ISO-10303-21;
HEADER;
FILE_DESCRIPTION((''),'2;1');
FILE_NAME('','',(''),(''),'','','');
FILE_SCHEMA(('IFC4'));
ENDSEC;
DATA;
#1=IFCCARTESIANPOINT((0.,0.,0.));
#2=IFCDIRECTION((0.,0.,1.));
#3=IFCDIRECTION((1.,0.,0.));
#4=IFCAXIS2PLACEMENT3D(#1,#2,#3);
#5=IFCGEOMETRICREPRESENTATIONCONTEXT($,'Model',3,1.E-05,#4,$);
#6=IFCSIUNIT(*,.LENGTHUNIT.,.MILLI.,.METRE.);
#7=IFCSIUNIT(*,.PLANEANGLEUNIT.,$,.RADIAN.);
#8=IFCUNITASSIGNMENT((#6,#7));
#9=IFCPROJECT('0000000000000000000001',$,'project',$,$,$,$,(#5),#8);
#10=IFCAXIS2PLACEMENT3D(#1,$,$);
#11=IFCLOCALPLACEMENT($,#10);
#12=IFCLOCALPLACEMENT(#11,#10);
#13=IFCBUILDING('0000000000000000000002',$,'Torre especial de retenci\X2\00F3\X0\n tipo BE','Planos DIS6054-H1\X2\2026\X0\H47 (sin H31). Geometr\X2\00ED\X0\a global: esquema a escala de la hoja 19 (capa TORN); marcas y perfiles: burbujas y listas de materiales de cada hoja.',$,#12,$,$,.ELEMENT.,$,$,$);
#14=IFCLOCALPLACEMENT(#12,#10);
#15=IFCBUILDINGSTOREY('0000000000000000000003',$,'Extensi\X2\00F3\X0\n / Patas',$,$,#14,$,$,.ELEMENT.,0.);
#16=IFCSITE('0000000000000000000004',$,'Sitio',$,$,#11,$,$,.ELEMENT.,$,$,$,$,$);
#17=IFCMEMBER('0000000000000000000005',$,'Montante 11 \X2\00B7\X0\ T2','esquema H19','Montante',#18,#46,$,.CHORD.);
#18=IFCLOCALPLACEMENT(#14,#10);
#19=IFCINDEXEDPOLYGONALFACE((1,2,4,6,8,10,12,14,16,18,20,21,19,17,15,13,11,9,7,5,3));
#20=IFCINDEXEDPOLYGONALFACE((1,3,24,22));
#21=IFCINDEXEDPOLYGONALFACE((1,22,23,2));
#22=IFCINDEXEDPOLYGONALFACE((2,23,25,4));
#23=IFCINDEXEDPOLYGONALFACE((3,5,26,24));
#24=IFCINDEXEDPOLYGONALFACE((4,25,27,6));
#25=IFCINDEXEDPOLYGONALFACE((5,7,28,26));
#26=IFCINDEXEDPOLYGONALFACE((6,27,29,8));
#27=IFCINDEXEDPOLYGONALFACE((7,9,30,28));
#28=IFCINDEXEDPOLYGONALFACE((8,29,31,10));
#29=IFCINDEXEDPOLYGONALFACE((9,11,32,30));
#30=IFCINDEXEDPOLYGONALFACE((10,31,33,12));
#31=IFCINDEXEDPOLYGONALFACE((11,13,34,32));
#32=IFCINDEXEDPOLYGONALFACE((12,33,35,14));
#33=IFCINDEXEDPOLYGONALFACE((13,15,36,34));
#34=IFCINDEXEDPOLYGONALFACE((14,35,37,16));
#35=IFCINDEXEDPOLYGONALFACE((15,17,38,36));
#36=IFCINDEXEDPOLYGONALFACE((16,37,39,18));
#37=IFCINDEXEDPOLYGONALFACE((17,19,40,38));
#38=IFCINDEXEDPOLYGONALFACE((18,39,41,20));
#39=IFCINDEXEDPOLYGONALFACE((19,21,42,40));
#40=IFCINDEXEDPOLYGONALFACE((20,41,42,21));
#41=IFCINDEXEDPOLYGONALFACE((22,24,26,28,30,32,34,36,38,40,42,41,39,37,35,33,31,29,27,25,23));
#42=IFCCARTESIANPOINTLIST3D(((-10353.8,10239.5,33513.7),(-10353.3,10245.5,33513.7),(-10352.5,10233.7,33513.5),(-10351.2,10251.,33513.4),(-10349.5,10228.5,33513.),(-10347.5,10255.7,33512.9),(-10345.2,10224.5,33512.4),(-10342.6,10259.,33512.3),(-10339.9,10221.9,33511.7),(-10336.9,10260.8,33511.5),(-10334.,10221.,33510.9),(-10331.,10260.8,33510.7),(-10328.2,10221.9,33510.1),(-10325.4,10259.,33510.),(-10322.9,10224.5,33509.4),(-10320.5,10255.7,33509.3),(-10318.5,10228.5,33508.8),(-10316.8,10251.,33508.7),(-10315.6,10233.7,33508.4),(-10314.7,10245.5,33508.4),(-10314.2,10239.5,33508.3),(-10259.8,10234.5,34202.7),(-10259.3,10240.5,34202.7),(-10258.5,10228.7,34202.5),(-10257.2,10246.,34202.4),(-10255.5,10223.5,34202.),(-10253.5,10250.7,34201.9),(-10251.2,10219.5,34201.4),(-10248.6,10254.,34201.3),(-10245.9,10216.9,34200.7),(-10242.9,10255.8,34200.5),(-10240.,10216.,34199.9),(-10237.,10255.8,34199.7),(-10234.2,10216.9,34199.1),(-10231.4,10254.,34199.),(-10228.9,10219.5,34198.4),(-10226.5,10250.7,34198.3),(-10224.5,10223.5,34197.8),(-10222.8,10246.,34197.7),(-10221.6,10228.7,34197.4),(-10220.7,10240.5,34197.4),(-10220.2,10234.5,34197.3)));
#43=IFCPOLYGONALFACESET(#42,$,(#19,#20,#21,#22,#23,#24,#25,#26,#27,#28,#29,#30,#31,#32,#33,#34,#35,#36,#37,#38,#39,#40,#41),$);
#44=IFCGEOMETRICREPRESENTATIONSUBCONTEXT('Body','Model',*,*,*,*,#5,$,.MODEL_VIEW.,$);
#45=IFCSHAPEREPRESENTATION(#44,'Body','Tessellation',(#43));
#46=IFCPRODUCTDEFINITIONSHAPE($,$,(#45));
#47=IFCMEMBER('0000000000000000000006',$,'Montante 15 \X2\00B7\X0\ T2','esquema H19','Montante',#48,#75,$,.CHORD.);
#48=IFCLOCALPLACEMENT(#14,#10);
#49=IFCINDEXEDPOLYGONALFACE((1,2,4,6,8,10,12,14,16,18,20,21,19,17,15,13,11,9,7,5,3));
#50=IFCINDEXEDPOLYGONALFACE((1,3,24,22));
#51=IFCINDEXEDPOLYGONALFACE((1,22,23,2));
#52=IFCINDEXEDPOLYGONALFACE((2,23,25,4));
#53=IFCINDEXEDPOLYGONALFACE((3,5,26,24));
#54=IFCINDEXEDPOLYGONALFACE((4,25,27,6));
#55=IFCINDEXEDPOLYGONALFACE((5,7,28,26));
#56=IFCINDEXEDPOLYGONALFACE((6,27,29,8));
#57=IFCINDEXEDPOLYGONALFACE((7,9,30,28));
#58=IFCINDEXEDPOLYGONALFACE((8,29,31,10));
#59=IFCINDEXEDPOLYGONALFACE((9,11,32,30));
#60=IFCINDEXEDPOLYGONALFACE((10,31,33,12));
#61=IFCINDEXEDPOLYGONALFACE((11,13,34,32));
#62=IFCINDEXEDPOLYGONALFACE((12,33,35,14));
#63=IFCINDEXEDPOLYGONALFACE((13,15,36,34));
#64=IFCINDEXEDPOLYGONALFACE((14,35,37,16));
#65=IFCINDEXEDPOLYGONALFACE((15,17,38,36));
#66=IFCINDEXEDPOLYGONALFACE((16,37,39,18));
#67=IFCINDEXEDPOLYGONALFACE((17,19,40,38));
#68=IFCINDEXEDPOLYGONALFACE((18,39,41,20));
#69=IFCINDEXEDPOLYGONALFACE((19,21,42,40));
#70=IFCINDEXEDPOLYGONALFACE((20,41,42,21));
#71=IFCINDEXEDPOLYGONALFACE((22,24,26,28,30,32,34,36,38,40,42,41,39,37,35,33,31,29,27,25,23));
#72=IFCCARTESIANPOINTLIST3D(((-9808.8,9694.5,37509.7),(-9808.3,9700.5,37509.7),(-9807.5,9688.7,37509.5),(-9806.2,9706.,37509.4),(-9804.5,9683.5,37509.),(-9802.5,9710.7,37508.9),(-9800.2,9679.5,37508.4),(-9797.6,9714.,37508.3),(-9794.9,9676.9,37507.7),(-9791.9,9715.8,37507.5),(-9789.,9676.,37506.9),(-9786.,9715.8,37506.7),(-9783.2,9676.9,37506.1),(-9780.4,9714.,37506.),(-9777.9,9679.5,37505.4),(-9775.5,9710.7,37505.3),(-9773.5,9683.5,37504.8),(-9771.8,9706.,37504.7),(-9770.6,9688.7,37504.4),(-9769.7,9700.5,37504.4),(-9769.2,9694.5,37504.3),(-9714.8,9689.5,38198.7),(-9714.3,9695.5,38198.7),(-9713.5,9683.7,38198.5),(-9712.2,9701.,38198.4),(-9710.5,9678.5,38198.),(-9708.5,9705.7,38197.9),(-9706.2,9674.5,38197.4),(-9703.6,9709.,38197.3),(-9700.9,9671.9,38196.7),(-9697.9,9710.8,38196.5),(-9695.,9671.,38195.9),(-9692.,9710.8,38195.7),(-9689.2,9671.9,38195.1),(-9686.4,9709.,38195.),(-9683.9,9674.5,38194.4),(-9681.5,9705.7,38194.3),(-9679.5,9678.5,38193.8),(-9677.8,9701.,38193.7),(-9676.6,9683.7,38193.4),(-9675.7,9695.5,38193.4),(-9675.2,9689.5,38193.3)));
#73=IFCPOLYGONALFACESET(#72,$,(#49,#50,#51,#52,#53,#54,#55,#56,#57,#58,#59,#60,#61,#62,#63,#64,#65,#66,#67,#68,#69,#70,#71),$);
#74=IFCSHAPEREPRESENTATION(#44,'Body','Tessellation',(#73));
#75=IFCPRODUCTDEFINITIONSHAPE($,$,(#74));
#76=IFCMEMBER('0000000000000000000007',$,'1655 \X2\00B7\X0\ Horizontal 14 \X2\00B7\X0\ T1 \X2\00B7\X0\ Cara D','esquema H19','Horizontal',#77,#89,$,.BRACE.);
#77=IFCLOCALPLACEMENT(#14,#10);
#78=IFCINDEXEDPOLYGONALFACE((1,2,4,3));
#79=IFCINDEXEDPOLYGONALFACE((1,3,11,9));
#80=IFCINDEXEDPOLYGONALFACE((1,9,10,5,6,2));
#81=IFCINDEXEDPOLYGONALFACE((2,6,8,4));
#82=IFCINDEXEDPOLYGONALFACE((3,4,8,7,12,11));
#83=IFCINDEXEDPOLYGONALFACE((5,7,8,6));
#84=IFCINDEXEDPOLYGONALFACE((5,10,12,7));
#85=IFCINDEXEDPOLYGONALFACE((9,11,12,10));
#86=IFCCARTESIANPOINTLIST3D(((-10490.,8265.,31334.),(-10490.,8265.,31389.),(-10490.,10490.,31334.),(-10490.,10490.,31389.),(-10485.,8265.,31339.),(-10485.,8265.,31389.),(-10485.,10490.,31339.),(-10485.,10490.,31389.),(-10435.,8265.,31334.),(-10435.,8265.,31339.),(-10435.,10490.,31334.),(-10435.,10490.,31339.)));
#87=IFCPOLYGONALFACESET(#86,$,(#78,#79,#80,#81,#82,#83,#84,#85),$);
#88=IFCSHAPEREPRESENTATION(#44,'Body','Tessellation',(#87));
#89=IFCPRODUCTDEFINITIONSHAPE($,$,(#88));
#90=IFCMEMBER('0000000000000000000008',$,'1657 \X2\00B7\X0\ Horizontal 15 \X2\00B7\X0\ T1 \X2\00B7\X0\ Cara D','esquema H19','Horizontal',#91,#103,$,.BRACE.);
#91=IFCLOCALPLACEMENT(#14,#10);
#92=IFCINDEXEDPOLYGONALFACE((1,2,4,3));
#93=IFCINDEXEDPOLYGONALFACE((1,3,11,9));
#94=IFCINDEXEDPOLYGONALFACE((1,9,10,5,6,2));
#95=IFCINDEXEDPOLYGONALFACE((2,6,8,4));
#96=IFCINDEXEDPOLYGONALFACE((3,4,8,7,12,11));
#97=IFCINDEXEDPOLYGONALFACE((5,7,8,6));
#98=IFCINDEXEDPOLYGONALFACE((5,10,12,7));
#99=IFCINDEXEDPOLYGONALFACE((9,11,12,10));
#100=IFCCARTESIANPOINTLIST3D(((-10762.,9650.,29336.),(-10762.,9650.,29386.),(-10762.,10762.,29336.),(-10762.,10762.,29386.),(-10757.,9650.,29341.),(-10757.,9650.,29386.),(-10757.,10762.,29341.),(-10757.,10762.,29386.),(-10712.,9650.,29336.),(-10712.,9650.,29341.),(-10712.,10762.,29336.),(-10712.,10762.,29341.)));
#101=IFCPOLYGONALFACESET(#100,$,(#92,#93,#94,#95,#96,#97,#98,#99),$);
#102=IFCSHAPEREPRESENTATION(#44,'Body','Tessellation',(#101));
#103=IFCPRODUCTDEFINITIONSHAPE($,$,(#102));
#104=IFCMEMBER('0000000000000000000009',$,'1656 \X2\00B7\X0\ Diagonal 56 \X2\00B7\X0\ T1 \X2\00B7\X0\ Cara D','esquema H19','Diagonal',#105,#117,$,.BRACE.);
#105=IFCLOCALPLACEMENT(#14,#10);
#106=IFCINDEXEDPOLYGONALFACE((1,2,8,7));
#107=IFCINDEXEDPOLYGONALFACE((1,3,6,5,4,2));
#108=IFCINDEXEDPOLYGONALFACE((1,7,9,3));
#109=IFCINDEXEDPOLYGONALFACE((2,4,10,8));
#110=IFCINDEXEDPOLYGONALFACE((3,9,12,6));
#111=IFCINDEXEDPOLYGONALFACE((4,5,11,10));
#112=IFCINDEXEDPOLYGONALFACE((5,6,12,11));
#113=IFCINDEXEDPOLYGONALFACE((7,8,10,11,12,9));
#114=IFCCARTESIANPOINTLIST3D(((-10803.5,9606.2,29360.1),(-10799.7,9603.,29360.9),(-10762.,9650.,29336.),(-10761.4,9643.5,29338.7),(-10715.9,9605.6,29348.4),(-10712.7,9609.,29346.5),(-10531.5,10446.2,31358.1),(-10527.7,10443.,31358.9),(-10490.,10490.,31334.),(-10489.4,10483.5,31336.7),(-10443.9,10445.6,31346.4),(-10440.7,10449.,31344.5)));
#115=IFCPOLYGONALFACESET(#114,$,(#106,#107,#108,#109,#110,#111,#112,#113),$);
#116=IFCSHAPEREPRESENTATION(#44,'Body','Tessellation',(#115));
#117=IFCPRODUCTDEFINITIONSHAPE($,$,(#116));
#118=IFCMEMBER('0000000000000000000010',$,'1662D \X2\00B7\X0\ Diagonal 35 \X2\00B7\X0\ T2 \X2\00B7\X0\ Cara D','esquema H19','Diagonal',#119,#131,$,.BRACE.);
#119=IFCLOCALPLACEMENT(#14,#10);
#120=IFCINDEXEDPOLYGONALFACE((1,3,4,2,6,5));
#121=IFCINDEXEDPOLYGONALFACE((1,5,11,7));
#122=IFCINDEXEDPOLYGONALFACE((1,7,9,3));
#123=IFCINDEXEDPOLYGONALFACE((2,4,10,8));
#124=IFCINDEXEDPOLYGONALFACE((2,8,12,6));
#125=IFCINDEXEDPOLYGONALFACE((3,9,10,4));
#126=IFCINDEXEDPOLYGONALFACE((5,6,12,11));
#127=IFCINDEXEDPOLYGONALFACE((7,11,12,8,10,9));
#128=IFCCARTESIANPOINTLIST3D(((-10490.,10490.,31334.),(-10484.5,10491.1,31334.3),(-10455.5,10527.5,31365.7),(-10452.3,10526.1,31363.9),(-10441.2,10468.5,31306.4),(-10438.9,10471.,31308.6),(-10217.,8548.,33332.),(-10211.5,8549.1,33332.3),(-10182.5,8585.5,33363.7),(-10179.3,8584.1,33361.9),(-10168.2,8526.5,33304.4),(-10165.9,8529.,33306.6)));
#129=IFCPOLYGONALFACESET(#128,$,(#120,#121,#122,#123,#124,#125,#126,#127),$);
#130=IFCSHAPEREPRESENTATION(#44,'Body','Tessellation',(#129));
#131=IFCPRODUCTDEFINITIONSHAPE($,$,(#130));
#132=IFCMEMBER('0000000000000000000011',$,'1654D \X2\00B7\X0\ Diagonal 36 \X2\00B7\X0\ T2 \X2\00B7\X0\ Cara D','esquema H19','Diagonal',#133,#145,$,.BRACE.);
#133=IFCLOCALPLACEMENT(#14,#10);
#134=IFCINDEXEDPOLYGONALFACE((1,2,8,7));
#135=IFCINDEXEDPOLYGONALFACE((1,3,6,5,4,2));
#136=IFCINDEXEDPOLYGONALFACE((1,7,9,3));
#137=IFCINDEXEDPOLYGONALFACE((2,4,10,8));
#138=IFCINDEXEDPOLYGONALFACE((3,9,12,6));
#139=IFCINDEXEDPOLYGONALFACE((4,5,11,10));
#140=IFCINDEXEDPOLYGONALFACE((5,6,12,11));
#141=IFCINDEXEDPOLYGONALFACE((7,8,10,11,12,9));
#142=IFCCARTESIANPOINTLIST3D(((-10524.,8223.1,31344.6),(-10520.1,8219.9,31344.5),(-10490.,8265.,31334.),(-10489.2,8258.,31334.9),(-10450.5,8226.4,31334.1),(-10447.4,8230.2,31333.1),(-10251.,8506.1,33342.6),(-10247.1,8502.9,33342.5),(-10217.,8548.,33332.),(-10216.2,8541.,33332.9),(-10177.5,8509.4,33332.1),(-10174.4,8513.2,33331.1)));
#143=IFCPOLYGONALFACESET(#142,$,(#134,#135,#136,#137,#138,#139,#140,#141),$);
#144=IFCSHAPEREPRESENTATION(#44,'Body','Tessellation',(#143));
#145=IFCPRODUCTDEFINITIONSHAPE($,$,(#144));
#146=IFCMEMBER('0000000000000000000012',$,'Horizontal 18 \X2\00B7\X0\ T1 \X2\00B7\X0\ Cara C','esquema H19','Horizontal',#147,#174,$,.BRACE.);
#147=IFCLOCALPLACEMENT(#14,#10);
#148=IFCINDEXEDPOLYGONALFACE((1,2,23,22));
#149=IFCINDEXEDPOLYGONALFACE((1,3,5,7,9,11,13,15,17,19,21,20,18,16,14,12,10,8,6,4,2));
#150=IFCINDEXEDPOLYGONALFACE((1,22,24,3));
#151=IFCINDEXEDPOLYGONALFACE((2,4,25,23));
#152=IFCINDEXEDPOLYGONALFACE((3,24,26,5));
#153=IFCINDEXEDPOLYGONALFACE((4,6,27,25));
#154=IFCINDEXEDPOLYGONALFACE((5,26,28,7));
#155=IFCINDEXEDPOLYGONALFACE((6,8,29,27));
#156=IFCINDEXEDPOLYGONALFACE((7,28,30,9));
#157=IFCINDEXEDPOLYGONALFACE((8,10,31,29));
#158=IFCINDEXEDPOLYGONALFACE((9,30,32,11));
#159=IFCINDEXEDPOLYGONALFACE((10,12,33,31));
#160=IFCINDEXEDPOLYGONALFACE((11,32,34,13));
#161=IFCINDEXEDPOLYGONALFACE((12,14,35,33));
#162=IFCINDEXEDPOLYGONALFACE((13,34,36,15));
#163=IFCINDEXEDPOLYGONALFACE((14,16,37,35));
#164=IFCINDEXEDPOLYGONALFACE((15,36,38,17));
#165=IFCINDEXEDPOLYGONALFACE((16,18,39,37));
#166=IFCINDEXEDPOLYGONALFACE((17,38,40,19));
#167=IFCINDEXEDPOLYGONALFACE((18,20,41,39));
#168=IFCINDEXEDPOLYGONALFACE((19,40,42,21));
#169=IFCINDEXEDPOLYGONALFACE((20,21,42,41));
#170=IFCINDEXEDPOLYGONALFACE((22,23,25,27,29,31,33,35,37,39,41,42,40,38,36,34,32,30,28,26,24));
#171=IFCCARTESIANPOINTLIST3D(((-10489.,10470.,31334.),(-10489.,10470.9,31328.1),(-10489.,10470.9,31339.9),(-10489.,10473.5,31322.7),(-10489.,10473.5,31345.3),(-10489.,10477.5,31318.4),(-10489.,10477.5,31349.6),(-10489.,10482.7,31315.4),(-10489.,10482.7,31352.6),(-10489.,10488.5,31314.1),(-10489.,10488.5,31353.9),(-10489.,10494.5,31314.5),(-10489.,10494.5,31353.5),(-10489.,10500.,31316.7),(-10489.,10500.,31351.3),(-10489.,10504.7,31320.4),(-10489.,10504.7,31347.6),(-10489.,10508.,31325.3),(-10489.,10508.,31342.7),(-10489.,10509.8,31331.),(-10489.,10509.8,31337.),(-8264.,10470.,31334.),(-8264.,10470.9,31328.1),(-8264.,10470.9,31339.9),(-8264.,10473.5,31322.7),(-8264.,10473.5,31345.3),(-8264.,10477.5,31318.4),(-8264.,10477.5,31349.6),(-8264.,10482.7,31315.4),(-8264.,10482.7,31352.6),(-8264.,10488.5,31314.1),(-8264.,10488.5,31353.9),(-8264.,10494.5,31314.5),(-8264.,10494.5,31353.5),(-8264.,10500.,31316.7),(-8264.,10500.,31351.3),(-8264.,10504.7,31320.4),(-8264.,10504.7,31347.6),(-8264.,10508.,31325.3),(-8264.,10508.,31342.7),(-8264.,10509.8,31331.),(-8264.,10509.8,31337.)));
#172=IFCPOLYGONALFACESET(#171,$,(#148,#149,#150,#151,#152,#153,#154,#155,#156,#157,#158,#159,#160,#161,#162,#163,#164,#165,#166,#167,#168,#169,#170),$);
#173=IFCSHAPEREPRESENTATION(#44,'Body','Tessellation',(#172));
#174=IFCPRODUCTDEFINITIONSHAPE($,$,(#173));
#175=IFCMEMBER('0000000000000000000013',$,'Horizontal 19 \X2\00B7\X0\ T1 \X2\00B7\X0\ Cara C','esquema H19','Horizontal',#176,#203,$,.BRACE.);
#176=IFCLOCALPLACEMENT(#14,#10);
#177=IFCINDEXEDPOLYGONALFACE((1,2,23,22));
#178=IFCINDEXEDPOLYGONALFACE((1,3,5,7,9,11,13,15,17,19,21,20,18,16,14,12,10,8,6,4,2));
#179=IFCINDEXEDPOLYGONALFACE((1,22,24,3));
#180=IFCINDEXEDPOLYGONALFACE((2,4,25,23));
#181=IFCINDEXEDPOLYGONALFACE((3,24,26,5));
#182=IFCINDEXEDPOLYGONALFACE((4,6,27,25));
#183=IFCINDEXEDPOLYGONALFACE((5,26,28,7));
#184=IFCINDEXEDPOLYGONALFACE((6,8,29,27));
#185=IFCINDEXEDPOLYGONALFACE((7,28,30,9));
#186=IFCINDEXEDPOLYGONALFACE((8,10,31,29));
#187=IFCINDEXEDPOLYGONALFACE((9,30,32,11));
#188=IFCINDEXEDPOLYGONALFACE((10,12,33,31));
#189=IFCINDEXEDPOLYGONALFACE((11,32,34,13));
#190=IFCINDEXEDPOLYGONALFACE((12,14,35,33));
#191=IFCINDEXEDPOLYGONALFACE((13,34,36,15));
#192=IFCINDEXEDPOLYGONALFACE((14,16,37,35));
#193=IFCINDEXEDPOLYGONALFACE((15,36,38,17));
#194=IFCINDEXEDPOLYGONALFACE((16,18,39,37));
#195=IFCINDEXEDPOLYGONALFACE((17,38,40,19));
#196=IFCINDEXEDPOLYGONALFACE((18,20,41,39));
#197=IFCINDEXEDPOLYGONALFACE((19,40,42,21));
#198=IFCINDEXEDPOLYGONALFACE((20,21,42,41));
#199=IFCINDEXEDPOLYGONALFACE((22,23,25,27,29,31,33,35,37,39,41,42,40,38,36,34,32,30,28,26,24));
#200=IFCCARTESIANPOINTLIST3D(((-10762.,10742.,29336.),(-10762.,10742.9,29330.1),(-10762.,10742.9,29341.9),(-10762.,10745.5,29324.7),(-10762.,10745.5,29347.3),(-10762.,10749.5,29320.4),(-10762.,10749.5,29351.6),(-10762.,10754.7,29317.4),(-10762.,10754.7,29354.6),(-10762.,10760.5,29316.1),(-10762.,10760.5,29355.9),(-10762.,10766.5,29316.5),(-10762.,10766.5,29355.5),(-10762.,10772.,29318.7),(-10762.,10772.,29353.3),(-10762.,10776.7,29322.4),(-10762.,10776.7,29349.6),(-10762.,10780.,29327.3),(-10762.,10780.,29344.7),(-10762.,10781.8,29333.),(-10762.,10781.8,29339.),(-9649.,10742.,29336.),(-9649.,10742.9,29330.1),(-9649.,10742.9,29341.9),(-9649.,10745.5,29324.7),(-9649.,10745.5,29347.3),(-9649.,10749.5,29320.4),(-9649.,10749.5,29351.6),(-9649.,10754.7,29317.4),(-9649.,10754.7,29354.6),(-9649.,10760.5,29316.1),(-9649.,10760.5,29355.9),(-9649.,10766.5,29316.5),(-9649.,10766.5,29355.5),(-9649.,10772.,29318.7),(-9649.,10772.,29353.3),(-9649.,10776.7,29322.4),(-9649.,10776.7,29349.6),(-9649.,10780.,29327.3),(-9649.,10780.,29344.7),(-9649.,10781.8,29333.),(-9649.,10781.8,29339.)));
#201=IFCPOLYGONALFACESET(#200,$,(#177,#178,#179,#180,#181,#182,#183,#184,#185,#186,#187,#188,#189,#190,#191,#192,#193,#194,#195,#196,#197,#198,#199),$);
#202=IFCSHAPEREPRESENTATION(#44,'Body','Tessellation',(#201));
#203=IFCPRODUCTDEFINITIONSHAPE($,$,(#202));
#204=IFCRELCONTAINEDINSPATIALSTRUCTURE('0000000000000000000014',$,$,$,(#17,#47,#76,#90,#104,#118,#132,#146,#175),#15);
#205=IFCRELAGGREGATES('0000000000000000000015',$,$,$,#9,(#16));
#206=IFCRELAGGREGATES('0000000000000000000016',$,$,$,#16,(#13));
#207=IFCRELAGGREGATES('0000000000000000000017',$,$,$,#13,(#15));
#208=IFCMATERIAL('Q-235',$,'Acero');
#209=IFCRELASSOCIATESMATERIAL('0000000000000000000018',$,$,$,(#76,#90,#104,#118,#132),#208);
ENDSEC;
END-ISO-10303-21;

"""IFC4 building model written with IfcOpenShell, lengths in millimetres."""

from ifc_helpers import new_model, si_unit, frame, frame_2d, origin, origin_with_axes, place, context, subcontext, project, spatial, circle, l_section, extrude, material, element, save


model = new_model("IFC4")

# Units and contexts
model_context = context("Model", 3, precision=1e-05, world=origin_with_axes())
body_context = subcontext(model_context, "Body", "Model", "MODEL_VIEW")
ifc_project = project(units=[si_unit("LENGTHUNIT", "METRE", prefix="MILLI"), si_unit("PLANEANGLEUNIT", "RADIAN")], contexts=[model_context])

# Site, building, storey
site_placement = place(None, origin())
site = spatial("IfcSite", under=ifc_project, at=site_placement, Name="Sitio", CompositionType="ELEMENT")
building_placement = place(site_placement, origin())
building = spatial("IfcBuilding", under=site, at=building_placement, Name="Torre especial de retención tipo BE", Description="Planos DIS6054-H1…H47 (sin H31). Geometría global: esquema a escala de la hoja 19 (capa TORN); marcas y perfiles: burbujas y listas de materiales de cada hoja.", CompositionType="ELEMENT")
storey_placement = place(building_placement, origin())
storey = spatial("IfcBuildingStorey", under=building, at=storey_placement, Name="Extensión / Patas", CompositionType="ELEMENT", Elevation=0.0)

# Members
for number, where, z_axis, x_axis, name in (
    (1, (-10334.0, 10241.0, 33511.0), (0.135174, -0.00719, 0.990796), (-0.000972, -0.999974, -0.007124), "Montante 11 · T2"),
    (2, (-9789.0, 9696.0, 37507.0), (0.135174, -0.00719, 0.990796), (-0.000972, -0.999974, -0.007124), "Montante 15 · T2"),
):
    element("IfcMember", number, at=place(storey_placement, frame(where, z_axis=z_axis, x_axis=x_axis)), inside=storey, Name=name, Description="esquema H19", ObjectType="Montante", PredefinedType="CHORD", context=body_context, shape_type="SweptSolid", body=[
        extrude(circle(Radius=20.0), None, (0.0, 0.0, 1.0), 695.4),
    ])
ifc_material_1 = material(Name="Q-235", Category="Acero")
member_1_placement = place(storey_placement, frame((-10490.0, 10490.0, 31334.0), z_axis=(0.0, -1.0, 0.0), x_axis=(1.0, 0.0, 0.0)))
element("IfcMember", 3, at=member_1_placement, inside=storey, material=ifc_material_1, Name="1655 · Horizontal 14 · T1 · Cara D", Description="esquema H19", ObjectType="Horizontal", PredefinedType="BRACE", context=body_context, shape_type="SweptSolid", body=[
    extrude(l_section(Depth=55.0, Width=55.0, Thickness=5.0, at=frame_2d((27.5, 27.5))), None, (0.0, 0.0, 1.0), 2225.0),
])
member_2_placement = place(storey_placement, frame((-10762.0, 10762.0, 29336.0), z_axis=(0.0, -1.0, 0.0), x_axis=(1.0, 0.0, 0.0)))
element("IfcMember", 4, at=member_2_placement, inside=storey, material=ifc_material_1, Name="1657 · Horizontal 15 · T1 · Cara D", Description="esquema H19", ObjectType="Horizontal", PredefinedType="BRACE", context=body_context, shape_type="SweptSolid", body=[
    extrude(l_section(Depth=50.0, Width=50.0, Thickness=5.0, at=frame_2d((25.0, 25.0))), None, (0.0, 0.0, 1.0), 1112.0),
])
member_3_placement = place(storey_placement, frame((-10490.0, 10490.0, 31334.0), z_axis=(-0.12452, -0.384546, -0.914669), x_axis=(0.759122, -0.630533, 0.161745)))
element("IfcMember", 5, at=member_3_placement, inside=storey, material=ifc_material_1, Name="1656 · Diagonal 56 · T1 · Cara D", Description="esquema H19", ObjectType="Diagonal", PredefinedType="BRACE", context=body_context, shape_type="SweptSolid", body=[
    extrude(l_section(Depth=65.0, Width=65.0, Thickness=5.0, at=frame_2d((32.5, 32.5))), None, (0.0, 0.0, 1.0), 2184.4),
])
member_4_placement = place(storey_placement, frame((-10490.0, 10490.0, 31334.0), z_axis=(0.097513, -0.693664, 0.713667), x_axis=(0.812714, -0.358397, -0.459399)))
element("IfcMember", 6, at=member_4_placement, inside=storey, material=ifc_material_1, Name="1662D · Diagonal 35 · T2 · Cara D", Description="esquema H19", ObjectType="Diagonal", PredefinedType="BRACE", context=body_context, shape_type="SweptSolid", body=[
    extrude(l_section(Depth=60.0, Width=60.0, Thickness=4.0, at=frame_2d((30.0, 30.0))), None, (0.0, 0.0, 1.0), 2799.6),
])
member_5_placement = place(storey_placement, frame((-10217.0, 8548.0, 33332.0), z_axis=(-0.134065, -0.138976, -0.981179), x_axis=(0.77422, -0.63271, -0.016169)))
element("IfcMember", 7, at=member_5_placement, inside=storey, material=ifc_material_1, Name="1654D · Diagonal 36 · T2 · Cara D", Description="esquema H19", ObjectType="Diagonal", PredefinedType="BRACE", context=body_context, shape_type="SweptSolid", body=[
    extrude(l_section(Depth=55.0, Width=55.0, Thickness=5.0, at=frame_2d((27.5, 27.5))), None, (0.0, 0.0, 1.0), 2036.3),
])
member_6_placement = place(storey_placement, frame((-10489.0, 10490.0, 31334.0), z_axis=(1.0, 0.0, 0.0), x_axis=(0.0, -1.0, 0.0)))
element("IfcMember", 8, at=member_6_placement, inside=storey, Name="Horizontal 18 · T1 · Cara C", Description="esquema H19", ObjectType="Horizontal", PredefinedType="BRACE", context=body_context, shape_type="SweptSolid", body=[
    extrude(circle(Radius=20.0), None, (0.0, 0.0, 1.0), 2225.0),
])
member_7_placement = place(storey_placement, frame((-10762.0, 10762.0, 29336.0), z_axis=(1.0, 0.0, 0.0), x_axis=(0.0, -1.0, 0.0)))
element("IfcMember", 9, at=member_7_placement, inside=storey, Name="Horizontal 19 · T1 · Cara C", Description="esquema H19", ObjectType="Horizontal", PredefinedType="BRACE", context=body_context, shape_type="SweptSolid", body=[
    extrude(circle(Radius=20.0), None, (0.0, 0.0, 1.0), 1113.0),
])

save(model, "model.ifc")
